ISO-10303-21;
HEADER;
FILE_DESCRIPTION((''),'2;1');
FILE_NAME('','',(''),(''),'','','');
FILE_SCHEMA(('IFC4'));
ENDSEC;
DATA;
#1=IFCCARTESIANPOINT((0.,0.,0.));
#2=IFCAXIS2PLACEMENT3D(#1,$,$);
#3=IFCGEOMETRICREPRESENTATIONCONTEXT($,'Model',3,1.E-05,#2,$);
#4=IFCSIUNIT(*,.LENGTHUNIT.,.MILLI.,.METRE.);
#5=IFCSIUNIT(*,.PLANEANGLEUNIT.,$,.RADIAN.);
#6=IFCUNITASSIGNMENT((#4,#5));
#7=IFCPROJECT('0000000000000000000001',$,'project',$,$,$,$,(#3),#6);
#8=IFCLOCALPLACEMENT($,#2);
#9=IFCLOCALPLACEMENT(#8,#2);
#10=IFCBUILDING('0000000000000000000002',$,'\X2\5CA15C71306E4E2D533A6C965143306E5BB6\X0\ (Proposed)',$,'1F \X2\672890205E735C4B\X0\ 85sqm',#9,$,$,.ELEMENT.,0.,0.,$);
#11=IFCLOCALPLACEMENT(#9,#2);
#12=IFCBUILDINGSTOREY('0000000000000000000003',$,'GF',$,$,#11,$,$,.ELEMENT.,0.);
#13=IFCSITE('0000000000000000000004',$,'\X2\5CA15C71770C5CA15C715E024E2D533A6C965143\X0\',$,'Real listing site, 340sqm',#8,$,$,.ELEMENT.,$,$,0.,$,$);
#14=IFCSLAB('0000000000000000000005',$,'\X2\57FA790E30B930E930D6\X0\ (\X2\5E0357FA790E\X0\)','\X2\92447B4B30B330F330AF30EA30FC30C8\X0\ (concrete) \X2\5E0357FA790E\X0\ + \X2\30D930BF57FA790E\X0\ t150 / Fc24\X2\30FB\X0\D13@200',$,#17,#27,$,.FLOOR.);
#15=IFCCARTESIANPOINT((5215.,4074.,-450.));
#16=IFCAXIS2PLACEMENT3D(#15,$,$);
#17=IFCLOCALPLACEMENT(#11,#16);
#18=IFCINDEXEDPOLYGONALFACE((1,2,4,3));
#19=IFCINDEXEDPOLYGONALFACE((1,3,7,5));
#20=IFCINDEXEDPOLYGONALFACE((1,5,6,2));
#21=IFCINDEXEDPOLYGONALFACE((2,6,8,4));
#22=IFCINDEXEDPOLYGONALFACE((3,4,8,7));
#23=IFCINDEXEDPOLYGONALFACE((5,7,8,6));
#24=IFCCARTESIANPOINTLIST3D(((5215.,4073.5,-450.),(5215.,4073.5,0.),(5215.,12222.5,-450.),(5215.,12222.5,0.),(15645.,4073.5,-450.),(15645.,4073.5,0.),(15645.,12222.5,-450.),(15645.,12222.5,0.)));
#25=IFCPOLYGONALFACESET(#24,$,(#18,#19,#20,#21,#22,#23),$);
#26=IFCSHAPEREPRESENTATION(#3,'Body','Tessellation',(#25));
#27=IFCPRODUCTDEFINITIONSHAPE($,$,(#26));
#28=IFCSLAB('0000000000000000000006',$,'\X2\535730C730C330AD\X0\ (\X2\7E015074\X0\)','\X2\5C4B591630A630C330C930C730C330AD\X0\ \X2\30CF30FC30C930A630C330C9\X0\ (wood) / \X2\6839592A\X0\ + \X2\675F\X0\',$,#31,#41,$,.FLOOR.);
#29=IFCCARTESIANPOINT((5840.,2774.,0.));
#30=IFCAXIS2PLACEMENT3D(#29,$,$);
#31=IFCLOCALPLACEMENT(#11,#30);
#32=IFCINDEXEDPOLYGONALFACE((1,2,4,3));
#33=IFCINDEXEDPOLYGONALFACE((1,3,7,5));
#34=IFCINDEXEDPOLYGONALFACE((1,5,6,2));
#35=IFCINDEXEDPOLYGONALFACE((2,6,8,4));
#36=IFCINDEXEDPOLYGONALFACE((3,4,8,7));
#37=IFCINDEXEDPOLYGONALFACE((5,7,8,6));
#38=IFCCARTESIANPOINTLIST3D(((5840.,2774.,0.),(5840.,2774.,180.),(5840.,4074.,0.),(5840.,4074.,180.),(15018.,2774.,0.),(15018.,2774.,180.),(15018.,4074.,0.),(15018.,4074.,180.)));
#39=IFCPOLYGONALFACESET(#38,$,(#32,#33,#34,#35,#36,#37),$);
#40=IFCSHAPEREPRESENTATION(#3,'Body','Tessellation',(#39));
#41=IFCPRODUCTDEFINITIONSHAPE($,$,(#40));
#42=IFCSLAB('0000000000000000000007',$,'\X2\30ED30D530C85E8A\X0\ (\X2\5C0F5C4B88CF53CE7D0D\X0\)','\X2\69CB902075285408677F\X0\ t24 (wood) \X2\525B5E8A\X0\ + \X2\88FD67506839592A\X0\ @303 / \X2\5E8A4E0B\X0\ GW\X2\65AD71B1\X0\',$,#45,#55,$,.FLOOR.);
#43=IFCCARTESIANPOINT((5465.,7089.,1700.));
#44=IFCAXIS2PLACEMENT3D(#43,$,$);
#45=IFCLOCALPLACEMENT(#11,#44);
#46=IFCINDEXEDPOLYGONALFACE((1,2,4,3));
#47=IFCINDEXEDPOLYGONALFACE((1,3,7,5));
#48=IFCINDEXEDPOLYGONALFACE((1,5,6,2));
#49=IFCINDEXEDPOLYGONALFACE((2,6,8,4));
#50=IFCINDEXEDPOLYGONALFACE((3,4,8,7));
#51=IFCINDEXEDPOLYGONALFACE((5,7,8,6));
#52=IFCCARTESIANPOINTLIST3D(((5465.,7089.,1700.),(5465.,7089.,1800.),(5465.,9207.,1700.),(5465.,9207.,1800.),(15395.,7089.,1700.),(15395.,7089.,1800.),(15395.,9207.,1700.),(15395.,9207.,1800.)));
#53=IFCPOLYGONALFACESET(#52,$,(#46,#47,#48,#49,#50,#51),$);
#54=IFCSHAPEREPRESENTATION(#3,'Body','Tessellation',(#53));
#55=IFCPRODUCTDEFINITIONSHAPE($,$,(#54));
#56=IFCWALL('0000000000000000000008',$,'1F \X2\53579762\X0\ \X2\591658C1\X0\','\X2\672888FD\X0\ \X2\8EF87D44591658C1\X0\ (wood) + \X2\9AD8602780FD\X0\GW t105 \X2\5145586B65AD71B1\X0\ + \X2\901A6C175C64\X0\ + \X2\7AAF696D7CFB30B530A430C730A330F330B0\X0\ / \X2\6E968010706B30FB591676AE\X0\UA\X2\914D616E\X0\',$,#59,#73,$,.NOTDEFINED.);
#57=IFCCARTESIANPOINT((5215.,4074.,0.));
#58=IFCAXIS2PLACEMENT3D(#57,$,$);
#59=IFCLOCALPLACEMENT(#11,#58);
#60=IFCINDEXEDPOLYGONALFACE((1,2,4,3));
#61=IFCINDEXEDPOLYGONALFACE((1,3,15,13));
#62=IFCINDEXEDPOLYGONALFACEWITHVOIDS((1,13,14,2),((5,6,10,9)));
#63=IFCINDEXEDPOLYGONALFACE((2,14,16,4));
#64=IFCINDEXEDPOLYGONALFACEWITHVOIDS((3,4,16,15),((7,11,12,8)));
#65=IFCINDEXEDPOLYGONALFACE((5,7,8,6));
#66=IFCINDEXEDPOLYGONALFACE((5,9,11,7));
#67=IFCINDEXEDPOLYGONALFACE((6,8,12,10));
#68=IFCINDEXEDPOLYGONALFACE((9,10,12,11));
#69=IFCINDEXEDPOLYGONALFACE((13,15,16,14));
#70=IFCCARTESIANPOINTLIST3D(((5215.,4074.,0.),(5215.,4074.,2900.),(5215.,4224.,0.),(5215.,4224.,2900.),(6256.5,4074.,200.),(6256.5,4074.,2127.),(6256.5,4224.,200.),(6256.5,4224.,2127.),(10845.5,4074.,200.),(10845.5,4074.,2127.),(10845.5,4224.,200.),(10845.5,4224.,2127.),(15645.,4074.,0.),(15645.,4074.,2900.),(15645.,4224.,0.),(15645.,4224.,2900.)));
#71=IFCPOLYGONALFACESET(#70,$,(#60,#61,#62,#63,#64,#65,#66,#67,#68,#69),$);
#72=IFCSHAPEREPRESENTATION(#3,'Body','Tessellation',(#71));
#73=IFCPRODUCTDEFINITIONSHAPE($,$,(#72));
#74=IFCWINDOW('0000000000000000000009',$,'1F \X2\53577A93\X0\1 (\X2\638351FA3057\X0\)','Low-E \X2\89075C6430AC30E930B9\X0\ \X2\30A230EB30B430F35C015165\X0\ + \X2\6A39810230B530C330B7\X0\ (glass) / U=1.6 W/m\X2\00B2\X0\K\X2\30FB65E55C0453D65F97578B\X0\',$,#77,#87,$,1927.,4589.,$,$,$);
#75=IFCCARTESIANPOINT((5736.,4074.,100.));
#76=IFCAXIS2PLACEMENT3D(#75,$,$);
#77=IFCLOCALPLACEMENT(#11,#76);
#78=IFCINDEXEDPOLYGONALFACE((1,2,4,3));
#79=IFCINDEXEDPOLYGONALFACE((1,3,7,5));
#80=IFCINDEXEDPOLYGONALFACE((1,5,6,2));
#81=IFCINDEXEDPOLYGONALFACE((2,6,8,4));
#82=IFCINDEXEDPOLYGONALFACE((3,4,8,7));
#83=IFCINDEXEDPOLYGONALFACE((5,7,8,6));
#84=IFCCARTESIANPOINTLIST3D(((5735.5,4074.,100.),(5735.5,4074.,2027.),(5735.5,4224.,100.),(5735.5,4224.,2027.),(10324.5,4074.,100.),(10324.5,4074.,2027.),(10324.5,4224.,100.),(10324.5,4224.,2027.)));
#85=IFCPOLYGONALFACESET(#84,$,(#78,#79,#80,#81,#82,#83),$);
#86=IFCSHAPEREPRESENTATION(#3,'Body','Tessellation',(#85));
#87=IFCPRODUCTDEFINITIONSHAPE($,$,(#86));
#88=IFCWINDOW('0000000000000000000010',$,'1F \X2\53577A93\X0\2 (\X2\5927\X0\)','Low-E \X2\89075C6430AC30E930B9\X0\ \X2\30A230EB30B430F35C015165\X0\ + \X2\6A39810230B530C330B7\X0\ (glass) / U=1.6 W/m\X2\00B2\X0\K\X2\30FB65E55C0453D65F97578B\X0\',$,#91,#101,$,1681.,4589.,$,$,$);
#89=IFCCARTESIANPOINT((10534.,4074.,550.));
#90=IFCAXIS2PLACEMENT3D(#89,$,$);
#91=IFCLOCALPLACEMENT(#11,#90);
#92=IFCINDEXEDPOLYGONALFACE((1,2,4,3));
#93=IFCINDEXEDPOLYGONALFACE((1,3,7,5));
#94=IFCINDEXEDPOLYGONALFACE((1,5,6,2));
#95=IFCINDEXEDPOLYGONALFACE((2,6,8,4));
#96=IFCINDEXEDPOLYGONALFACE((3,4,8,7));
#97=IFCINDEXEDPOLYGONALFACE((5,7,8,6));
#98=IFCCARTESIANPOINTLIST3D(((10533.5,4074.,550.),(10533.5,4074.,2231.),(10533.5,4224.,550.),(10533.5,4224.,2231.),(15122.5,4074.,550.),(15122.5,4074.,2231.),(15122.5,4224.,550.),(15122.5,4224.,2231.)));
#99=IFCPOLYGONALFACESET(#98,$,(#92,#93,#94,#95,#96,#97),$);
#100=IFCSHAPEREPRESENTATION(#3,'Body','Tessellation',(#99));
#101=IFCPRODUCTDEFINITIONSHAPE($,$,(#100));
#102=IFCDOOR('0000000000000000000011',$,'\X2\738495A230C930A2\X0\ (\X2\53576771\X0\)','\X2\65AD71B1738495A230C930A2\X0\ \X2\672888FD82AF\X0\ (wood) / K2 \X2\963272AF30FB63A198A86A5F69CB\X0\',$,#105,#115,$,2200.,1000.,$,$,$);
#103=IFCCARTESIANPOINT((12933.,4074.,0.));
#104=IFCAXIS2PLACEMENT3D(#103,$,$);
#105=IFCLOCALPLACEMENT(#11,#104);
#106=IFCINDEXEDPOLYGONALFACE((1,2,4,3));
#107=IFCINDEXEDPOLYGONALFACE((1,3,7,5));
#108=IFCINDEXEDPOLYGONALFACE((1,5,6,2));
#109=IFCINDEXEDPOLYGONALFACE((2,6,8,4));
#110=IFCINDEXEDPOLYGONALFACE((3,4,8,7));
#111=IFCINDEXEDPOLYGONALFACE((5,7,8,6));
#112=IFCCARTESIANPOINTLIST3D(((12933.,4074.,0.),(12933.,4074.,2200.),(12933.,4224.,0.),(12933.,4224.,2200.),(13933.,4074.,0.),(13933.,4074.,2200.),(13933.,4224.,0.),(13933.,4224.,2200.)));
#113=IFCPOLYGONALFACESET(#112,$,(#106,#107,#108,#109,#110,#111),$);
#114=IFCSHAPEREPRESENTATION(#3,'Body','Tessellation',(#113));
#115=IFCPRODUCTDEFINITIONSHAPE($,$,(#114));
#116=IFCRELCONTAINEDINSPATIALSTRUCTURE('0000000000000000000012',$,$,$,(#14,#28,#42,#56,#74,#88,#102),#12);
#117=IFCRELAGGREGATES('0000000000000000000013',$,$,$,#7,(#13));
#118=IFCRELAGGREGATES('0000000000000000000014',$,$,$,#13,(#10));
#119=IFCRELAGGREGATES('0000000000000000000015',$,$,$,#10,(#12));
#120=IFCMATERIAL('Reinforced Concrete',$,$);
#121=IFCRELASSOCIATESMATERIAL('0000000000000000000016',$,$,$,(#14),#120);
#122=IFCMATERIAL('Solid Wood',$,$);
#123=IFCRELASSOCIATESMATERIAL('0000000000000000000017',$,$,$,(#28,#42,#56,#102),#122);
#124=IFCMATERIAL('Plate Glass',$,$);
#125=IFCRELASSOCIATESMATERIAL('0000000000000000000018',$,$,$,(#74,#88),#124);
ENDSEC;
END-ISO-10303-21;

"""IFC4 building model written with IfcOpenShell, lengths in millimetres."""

from ifc_helpers import new_model, si_unit, frame, frame_2d, origin, place, context, project, spatial, rectangle, extrude, material, element, fill, save


model = new_model("IFC4")

# Units and contexts
model_context = context("Model", 3, precision=1e-05, world=origin())
ifc_project = project(units=[si_unit("LENGTHUNIT", "METRE", prefix="MILLI"), si_unit("PLANEANGLEUNIT", "RADIAN")], contexts=[model_context])

# Site, building, storey
site_placement = place(None, origin())
site = spatial("IfcSite", under=ifc_project, at=site_placement, Name="岡山県岡山市中区沖元", ObjectType="Real listing site, 340sqm", CompositionType="ELEMENT", RefElevation=0.0)
building_placement = place(site_placement, origin())
building = spatial("IfcBuilding", under=site, at=building_placement, Name="岡山の中区沖元の家 (Proposed)", ObjectType="1F 木造平屋 85sqm", CompositionType="ELEMENT", ElevationOfRefHeight=0.0, ElevationOfTerrain=0.0)
storey_placement = place(building_placement, origin())
storey = spatial("IfcBuildingStorey", under=building, at=storey_placement, Name="GF", CompositionType="ELEMENT", Elevation=0.0)

# Slabs
ifc_material_1 = material(Name="Reinforced Concrete")
slab_1_placement = place(storey_placement, frame((5215.0, 4074.0, -450.0)))
element("IfcSlab", 1, at=slab_1_placement, inside=storey, material=ifc_material_1, Name="基礎スラブ (布基礎)", Description="鉄筋コンクリート (concrete) 布基礎 + ベタ基礎 t150 / Fc24・D13@200", PredefinedType="FLOOR", context=model_context, shape_type="SweptSolid", body=[
    extrude(rectangle(XDim=10430.0, YDim=8149.0, at=frame_2d((5215.0, 4074.0))), frame((5215.0, 4074.0, -450.0)), (0.0, 0.0, 1.0), 450.0),
])
ifc_material_2 = material(Name="Solid Wood")
slab_2_placement = place(storey_placement, frame((5840.0, 2774.0, 0.0)))
element("IfcSlab", 2, at=slab_2_placement, inside=storey, material=ifc_material_2, Name="南デッキ (縁側)", Description="屋外ウッドデッキ ハードウッド (wood) / 根太 + 束", PredefinedType="FLOOR", context=model_context, shape_type="SweptSolid", body=[
    extrude(rectangle(XDim=9178.0, YDim=1300.0, at=frame_2d((4589.0, 650.0))), frame((5840.0, 2774.0, 0.0)), (0.0, 0.0, 1.0), 180.0),
])
slab_3_placement = place(storey_placement, frame((5465.0, 7089.0, 1700.0)))
element("IfcSlab", 3, at=slab_3_placement, inside=storey, material=ifc_material_2, Name="ロフト床 (小屋裏収納)", Description="構造用合板 t24 (wood) 剛床 + 製材根太 @303 / 床下 GW断熱", PredefinedType="FLOOR", context=model_context, shape_type="SweptSolid", body=[
    extrude(rectangle(XDim=9930.0, YDim=2118.0, at=frame_2d((4965.0, 1059.0))), frame((5465.0, 7089.0, 1700.0)), (0.0, 0.0, 1.0), 100.0),
])

# Wall, openings, windows, door
wall_1_placement = place(storey_placement, frame((5215.0, 4074.0, 0.0)))
wall_1 = element("IfcWall", 4, at=wall_1_placement, inside=storey, material=ifc_material_2, Name="1F 南面 外壁", Description="木製 軸組外壁 (wood) + 高性能GW t105 充填断熱 + 通気層 + 窯業系サイディング / 準耐火・外皮UA配慮", PredefinedType="NOTDEFINED", context=model_context, shape_type="SweptSolid", body=[
    extrude(rectangle(XDim=10430.0, YDim=150.0, at=frame_2d((5215.0, 75.0))), frame((5215.0, 4074.0, 0.0)), (0.0, 0.0, 1.0), 2900.0),
])
opening_1_placement = place(storey_placement, frame((5736.0, 4074.0, 100.0)))
opening_1 = element("IfcOpeningElement", 5, at=opening_1_placement, cuts=wall_1, PredefinedType="NOTDEFINED", context=model_context, shape_type="SweptSolid", body=[
    extrude(rectangle(XDim=4589.0, YDim=150.0, at=frame_2d((2294.0, 75.0))), frame((5736.0, 4074.0, 100.0)), (0.0, 0.0, 1.0), 1927.0),
])
opening_2_placement = place(storey_placement, frame((10534.0, 4074.0, 550.0)))
opening_2 = element("IfcOpeningElement", 6, at=opening_2_placement, cuts=wall_1, PredefinedType="NOTDEFINED", context=model_context, shape_type="SweptSolid", body=[
    extrude(rectangle(XDim=4589.0, YDim=150.0, at=frame_2d((2294.0, 75.0))), frame((10534.0, 4074.0, 550.0)), (0.0, 0.0, 1.0), 1681.0),
])
opening_3_placement = place(storey_placement, frame((12933.0, 4074.0, 0.0)))
opening_3 = element("IfcOpeningElement", 7, at=opening_3_placement, cuts=wall_1, PredefinedType="NOTDEFINED", context=model_context, shape_type="SweptSolid", body=[
    extrude(rectangle(XDim=1000.0, YDim=150.0, at=frame_2d((500.0, 75.0))), frame((12933.0, 4074.0, 0.0)), (0.0, 0.0, 1.0), 2200.0),
])
ifc_material_3 = material(Name="Plate Glass")
window_1_placement = place(storey_placement, frame((5736.0, 4074.0, 100.0)))
window_1 = element("IfcWindow", 8, at=window_1_placement, inside=storey, material=ifc_material_3, Name="1F 南窓1 (掃出し)", Description="Low-E 複層ガラス アルゴン封入 + 樹脂サッシ (glass) / U=1.6 W/m²K・日射取得型", OverallHeight=1927.0, OverallWidth=4589.0, context=model_context, shape_type="SweptSolid", body=[
    extrude(rectangle(XDim=4589.0, YDim=150.0, at=frame_2d((2294.0, 75.0))), frame((5736.0, 4074.0, 100.0)), (0.0, 0.0, 1.0), 1927.0),
])
fill(opening_1, window_1)
window_2_placement = place(storey_placement, frame((10534.0, 4074.0, 550.0)))
window_2 = element("IfcWindow", 9, at=window_2_placement, inside=storey, material=ifc_material_3, Name="1F 南窓2 (大)", Description="Low-E 複層ガラス アルゴン封入 + 樹脂サッシ (glass) / U=1.6 W/m²K・日射取得型", OverallHeight=1681.0, OverallWidth=4589.0, context=model_context, shape_type="SweptSolid", body=[
    extrude(rectangle(XDim=4589.0, YDim=150.0, at=frame_2d((2294.0, 75.0))), frame((10534.0, 4074.0, 550.0)), (0.0, 0.0, 1.0), 1681.0),
])
fill(opening_2, window_2)
door_1_placement = place(storey_placement, frame((12933.0, 4074.0, 0.0)))
door_1 = element("IfcDoor", 10, at=door_1_placement, inside=storey, material=ifc_material_2, Name="玄関ドア (南東)", Description="断熱玄関ドア 木製芯 (wood) / K2 防犯・採風機構", OverallHeight=2200.0, OverallWidth=1000.0, context=model_context, shape_type="SweptSolid", body=[
    extrude(rectangle(XDim=1000.0, YDim=150.0, at=frame_2d((500.0, 75.0))), frame((12933.0, 4074.0, 0.0)), (0.0, 0.0, 1.0), 2200.0),
])
fill(opening_3, door_1)

save(model, "model.ifc")
